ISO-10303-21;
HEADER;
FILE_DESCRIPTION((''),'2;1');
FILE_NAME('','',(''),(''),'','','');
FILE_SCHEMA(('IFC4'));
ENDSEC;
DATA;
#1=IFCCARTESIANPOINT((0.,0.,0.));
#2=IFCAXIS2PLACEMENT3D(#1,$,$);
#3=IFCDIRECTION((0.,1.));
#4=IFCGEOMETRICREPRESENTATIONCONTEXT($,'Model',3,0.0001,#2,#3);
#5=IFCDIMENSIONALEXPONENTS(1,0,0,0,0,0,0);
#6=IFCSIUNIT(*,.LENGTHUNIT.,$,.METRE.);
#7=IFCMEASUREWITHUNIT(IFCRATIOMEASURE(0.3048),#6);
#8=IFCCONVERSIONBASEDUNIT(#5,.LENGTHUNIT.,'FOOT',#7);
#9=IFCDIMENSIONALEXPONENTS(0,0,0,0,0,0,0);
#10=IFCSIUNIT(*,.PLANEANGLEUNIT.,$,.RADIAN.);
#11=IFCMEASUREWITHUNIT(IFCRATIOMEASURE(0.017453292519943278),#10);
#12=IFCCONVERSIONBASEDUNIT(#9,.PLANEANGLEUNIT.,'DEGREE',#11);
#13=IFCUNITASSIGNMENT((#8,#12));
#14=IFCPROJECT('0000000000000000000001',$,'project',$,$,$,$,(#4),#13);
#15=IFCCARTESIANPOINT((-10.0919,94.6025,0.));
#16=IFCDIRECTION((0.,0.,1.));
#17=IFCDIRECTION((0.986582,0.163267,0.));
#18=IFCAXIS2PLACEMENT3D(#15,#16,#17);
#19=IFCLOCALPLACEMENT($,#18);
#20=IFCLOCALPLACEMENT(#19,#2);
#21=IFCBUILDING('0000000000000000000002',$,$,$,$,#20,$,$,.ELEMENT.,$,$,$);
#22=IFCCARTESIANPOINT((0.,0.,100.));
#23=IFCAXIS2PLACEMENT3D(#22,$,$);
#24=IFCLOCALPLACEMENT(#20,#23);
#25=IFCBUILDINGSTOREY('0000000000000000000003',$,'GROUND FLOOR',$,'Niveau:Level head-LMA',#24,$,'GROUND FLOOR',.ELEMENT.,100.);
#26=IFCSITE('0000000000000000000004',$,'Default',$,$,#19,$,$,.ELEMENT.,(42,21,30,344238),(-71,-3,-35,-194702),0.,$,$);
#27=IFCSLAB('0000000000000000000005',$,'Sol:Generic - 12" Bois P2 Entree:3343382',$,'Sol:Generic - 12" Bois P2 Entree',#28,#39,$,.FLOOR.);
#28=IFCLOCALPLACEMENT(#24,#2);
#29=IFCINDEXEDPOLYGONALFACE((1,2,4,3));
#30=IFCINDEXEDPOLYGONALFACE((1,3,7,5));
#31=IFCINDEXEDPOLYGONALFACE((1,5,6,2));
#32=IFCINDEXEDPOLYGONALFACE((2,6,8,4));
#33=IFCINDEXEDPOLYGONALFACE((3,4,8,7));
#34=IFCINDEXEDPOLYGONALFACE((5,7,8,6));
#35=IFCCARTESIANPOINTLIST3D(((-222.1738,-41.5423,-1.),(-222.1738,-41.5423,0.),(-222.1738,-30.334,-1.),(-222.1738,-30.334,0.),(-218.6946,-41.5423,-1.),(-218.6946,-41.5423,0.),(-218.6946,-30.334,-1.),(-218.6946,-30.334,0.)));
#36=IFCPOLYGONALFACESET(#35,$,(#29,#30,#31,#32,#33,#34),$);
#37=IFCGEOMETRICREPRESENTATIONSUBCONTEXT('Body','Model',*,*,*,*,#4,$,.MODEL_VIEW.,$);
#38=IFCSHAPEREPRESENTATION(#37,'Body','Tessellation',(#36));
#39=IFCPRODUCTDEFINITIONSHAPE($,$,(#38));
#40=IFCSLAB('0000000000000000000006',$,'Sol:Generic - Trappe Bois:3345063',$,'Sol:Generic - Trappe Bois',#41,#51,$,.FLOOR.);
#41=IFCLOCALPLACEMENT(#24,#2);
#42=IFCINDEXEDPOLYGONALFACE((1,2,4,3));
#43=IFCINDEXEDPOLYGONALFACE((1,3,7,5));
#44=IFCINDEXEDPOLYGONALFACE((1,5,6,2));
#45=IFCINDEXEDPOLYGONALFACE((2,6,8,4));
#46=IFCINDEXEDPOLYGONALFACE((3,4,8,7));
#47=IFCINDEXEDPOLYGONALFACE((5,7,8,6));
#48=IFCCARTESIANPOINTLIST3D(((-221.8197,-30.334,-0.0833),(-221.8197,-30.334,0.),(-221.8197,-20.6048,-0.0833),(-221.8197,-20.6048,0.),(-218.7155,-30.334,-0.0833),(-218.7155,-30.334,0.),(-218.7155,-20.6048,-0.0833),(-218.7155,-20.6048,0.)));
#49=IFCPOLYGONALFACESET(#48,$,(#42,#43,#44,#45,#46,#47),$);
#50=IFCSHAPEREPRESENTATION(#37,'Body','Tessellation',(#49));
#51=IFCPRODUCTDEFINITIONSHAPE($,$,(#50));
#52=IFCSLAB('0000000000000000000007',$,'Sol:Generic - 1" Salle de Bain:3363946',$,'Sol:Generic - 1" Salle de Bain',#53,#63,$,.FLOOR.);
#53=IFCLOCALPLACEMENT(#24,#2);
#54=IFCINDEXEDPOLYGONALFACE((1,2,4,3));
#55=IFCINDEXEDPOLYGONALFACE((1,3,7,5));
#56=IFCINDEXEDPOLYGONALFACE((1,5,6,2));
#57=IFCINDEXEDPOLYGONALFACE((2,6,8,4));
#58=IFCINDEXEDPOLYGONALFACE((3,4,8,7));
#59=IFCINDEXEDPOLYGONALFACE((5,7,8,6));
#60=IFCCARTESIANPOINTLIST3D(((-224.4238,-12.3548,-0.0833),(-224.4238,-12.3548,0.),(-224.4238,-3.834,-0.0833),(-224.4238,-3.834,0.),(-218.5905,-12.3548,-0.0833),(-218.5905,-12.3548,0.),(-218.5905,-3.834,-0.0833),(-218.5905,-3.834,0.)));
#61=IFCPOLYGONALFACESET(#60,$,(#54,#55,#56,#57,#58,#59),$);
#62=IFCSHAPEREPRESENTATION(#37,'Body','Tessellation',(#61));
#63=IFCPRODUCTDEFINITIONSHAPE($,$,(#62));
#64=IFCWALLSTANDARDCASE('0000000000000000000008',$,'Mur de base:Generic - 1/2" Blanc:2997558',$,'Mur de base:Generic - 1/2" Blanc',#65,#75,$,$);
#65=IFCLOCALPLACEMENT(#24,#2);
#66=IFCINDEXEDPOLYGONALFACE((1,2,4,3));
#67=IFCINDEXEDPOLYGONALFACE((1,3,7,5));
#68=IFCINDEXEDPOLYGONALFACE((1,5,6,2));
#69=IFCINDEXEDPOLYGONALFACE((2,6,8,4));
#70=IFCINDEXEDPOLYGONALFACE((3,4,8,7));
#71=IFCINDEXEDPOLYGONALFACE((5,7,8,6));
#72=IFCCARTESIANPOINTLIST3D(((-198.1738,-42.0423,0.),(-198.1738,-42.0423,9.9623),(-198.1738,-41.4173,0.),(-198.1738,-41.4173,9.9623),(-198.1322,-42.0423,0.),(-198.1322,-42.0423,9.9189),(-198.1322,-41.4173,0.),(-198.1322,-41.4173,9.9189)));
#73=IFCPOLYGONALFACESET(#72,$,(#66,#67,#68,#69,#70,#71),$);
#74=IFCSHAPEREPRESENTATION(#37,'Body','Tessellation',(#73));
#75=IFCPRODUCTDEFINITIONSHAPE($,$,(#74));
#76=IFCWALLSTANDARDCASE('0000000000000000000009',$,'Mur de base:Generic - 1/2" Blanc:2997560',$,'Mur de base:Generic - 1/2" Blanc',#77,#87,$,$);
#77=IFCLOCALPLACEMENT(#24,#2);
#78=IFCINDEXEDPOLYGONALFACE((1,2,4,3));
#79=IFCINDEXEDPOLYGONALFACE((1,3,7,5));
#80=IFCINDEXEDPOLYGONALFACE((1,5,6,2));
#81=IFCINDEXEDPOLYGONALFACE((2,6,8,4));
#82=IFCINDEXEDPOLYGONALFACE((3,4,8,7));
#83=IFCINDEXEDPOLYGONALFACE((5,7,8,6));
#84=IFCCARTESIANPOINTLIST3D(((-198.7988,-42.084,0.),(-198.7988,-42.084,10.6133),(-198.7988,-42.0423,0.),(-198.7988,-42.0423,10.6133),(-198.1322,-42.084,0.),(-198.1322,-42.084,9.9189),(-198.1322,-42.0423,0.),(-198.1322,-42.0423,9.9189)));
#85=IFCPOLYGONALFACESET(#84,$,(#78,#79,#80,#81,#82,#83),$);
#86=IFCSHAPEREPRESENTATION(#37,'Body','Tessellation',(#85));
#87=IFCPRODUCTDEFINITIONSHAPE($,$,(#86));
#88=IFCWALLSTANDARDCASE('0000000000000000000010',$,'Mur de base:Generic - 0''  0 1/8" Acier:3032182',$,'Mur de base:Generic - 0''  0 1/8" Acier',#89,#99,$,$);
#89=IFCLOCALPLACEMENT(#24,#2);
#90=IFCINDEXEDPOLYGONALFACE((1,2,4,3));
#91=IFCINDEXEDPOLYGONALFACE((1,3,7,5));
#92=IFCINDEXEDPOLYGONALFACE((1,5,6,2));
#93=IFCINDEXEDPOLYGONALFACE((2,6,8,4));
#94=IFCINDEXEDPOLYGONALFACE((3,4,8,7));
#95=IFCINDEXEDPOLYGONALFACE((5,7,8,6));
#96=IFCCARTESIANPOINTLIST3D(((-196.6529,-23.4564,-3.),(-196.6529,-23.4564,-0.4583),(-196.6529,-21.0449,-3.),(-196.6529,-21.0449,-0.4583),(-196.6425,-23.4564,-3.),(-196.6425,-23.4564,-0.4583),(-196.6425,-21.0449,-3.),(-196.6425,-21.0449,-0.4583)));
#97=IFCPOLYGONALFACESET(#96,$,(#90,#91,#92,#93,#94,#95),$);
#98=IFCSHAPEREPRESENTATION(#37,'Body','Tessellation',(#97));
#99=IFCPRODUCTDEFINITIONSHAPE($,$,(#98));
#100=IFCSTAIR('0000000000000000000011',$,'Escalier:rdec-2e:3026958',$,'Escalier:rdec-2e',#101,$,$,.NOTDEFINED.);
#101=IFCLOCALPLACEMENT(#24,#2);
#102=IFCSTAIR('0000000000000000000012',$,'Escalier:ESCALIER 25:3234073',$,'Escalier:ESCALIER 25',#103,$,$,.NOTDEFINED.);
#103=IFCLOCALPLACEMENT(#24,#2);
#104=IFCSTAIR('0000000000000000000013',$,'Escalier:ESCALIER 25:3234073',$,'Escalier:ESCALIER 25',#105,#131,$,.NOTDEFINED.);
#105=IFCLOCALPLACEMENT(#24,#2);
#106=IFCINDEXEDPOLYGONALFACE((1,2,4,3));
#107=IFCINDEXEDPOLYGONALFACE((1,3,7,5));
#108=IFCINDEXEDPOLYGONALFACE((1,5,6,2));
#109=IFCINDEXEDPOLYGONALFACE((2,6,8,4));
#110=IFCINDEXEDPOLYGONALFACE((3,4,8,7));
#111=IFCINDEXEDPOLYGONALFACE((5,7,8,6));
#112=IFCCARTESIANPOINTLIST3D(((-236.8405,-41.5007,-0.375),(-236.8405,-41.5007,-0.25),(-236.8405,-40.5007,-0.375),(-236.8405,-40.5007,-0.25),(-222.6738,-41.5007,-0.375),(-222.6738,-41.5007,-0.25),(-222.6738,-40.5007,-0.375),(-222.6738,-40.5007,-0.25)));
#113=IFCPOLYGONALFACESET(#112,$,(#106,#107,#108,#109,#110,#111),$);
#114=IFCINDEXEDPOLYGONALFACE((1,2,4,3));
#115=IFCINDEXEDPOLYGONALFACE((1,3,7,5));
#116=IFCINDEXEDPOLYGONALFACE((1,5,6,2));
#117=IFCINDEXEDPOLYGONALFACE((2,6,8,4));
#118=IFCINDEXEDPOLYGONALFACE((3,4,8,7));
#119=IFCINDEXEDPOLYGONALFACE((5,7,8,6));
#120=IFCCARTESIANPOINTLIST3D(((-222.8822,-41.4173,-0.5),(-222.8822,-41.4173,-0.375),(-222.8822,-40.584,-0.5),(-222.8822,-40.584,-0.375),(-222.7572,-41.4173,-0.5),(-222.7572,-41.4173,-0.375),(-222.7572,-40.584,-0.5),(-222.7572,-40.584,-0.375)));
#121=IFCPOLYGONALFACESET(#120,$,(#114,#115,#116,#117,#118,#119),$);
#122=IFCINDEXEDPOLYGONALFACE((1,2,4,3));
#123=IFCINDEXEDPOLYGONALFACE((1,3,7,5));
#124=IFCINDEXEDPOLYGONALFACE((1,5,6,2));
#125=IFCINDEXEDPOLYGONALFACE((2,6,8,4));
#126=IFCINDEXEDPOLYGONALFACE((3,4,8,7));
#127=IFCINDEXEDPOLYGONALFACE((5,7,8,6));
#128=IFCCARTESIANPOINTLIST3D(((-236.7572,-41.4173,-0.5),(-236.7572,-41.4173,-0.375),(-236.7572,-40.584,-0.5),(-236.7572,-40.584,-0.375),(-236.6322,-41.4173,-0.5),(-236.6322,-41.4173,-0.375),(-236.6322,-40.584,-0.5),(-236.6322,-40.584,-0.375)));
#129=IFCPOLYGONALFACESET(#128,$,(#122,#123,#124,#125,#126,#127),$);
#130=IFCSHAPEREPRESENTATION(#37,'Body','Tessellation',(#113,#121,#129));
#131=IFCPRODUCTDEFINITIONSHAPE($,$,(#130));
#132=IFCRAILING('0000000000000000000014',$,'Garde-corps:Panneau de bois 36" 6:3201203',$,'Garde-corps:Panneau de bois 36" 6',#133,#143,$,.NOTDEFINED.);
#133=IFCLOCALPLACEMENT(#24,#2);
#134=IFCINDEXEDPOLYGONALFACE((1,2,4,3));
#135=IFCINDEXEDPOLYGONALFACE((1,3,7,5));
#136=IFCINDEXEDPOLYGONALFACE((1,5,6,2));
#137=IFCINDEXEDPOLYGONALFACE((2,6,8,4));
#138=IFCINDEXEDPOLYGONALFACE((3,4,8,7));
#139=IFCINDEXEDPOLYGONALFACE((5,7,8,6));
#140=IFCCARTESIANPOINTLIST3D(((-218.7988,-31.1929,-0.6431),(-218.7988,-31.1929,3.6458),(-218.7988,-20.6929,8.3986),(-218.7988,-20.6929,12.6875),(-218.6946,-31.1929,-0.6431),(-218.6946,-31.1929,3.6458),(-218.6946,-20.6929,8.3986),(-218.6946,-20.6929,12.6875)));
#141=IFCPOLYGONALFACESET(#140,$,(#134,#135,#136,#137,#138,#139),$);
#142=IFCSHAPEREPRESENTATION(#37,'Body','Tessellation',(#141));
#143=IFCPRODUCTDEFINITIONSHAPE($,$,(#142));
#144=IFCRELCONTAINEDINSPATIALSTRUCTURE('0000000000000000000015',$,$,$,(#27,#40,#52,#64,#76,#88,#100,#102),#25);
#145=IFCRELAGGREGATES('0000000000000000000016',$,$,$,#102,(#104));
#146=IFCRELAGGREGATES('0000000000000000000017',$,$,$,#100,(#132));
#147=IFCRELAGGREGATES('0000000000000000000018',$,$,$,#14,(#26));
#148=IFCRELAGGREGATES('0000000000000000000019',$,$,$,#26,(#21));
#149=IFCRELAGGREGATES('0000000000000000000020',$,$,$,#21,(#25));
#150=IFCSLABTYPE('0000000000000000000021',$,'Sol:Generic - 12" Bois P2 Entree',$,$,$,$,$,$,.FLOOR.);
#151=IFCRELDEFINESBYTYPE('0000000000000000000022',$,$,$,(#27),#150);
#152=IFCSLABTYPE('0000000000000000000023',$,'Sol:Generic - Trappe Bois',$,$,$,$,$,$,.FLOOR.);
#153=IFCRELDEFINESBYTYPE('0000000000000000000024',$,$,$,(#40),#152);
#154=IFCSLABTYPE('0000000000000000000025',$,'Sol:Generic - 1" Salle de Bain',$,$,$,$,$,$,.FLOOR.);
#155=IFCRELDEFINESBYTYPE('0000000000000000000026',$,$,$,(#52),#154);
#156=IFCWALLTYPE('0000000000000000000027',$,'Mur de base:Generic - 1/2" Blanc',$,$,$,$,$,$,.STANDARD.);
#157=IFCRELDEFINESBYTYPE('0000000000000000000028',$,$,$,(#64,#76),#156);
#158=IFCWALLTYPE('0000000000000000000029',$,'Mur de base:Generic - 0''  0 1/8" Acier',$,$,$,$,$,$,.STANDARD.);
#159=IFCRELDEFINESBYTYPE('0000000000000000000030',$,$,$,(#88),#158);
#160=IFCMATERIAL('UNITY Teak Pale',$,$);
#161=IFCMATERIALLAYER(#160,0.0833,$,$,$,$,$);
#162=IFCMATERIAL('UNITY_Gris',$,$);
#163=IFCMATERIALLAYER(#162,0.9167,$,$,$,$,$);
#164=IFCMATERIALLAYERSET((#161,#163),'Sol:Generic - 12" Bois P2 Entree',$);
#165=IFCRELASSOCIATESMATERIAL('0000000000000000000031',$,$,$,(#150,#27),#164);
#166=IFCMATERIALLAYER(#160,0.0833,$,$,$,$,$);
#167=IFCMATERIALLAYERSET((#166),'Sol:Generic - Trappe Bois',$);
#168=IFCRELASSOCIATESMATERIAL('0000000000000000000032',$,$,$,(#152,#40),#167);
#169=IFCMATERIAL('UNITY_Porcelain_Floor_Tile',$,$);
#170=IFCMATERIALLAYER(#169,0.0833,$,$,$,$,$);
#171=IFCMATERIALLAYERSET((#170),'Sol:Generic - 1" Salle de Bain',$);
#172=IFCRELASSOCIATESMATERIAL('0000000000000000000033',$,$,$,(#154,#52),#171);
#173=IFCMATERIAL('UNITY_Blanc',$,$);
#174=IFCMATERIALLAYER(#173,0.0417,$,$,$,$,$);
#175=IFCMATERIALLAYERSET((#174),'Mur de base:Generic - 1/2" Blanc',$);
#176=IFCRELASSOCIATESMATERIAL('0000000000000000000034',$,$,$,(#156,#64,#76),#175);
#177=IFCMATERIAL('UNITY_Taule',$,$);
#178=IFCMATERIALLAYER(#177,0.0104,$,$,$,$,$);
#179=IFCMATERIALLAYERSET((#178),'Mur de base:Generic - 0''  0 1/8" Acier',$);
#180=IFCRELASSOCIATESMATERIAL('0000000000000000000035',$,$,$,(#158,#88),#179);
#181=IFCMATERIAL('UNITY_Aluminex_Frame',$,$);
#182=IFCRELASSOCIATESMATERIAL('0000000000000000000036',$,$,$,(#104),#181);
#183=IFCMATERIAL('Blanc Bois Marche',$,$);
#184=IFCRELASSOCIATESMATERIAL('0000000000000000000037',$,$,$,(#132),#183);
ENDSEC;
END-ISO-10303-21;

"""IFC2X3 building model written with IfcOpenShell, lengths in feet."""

from ifc_helpers import new_model, entity, si_unit, converted_unit, direction, frame, frame_2d, origin, place, context, subcontext, project, spatial, polyline, rectangle, outline, extrude, clip, bounded_halfspace, material, layer, layer_set, layer_usage, type_object, element, aggregate, save


model = new_model("IFC2X3")

# Units and contexts
model_context = context("Model", 3, precision=0.0001, world=origin(), true_north=direction((0.0, 1.0)))
body_context = subcontext(model_context, "Body", "Model", "MODEL_VIEW")
ifc_project = project(units=[converted_unit("LENGTHUNIT", "FOOT", entity("IfcRatioMeasure", 0.3048), si_unit("LENGTHUNIT", "METRE"), dimensions=[1, 0, 0, 0, 0, 0, 0]), converted_unit("PLANEANGLEUNIT", "DEGREE", entity("IfcRatioMeasure", 0.017453292519943278), si_unit("PLANEANGLEUNIT", "RADIAN"), dimensions=[0, 0, 0, 0, 0, 0, 0])], contexts=[model_context])

# Site, building, storey
site_placement = place(None, frame((-10.0919, 94.6025, 0.0), z_axis=(0.0, 0.0, 1.0), x_axis=(0.986582, 0.163267, 0.0)))
site = spatial("IfcSite", under=ifc_project, at=site_placement, Name="Default", CompositionType="ELEMENT", RefLatitude=(42, 21, 30, 344238), RefLongitude=(-71, -3, -35, -194702), RefElevation=0.0)
building_placement = place(site_placement, origin())
building = spatial("IfcBuilding", under=site, at=building_placement, CompositionType="ELEMENT")
storey_placement = place(building_placement, frame((0.0, 0.0, 100.0)))
storey = spatial("IfcBuildingStorey", under=building, at=storey_placement, Name="GROUND FLOOR", ObjectType="Niveau:Level head-LMA", LongName="GROUND FLOOR", CompositionType="ELEMENT", Elevation=100.0)

# Slabs
ifc_material_1 = material(Name="UNITY_Gris")
ifc_material_2 = material(Name="UNITY Teak Pale")
ifc_layer_1 = layer(ifc_material_2, 0.0833)
ifc_layer_2 = layer(ifc_material_1, 0.9167)
ifc_layer_set_1 = layer_set([ifc_layer_1, ifc_layer_2], Name="Sol:Generic - 12\" Bois P2 Entree")
ifc_layer_usage_1 = layer_usage(ifc_layer_set_1, "AXIS3", "POSITIVE", 0.0)
slab_type_1 = type_object("IfcSlabType", Name="Sol:Generic - 12\" Bois P2 Entree", PredefinedType="FLOOR", material=ifc_layer_set_1)
slab_1_placement = place(storey_placement, origin())
element("IfcSlab", 1, at=slab_1_placement, inside=storey, type_object=slab_type_1, material=ifc_layer_usage_1, Name="Sol:Generic - 12\" Bois P2 Entree:3343382", ObjectType="Sol:Generic - 12\" Bois P2 Entree", PredefinedType="FLOOR", context=body_context, shape_type="SweptSolid", body=[
    extrude(rectangle(XDim=11.2083, YDim=3.4792, at=frame_2d((0.0, 0.0), x_axis=(1.0, 0.0))), frame((-220.4342, -35.9382, 0.0), z_axis=(0.0, 0.0, -1.0), x_axis=(0.0, 1.0, 0.0)), (0.0, 0.0, 1.0), 1.0),
])
ifc_layer_3 = layer(ifc_material_2, 0.0833)
ifc_layer_set_2 = layer_set([ifc_layer_3], Name="Sol:Generic - Trappe Bois")
ifc_layer_usage_2 = layer_usage(ifc_layer_set_2, "AXIS3", "POSITIVE", 0.0)
slab_type_2 = type_object("IfcSlabType", Name="Sol:Generic - Trappe Bois", PredefinedType="FLOOR", material=ifc_layer_set_2)
slab_2_placement = place(storey_placement, origin())
element("IfcSlab", 2, at=slab_2_placement, inside=storey, type_object=slab_type_2, material=ifc_layer_usage_2, Name="Sol:Generic - Trappe Bois:3345063", ObjectType="Sol:Generic - Trappe Bois", PredefinedType="FLOOR", context=body_context, shape_type="SweptSolid", body=[
    extrude(rectangle(XDim=9.7292, YDim=3.1042, at=frame_2d((0.0, 0.0), x_axis=(1.0, 0.0))), frame((-220.2676, -25.4694, 0.0), z_axis=(0.0, 0.0, -1.0), x_axis=(0.0, 1.0, 0.0)), (0.0, 0.0, 1.0), 0.0833),
])
ifc_material_3 = material(Name="UNITY_Porcelain_Floor_Tile")
ifc_layer_4 = layer(ifc_material_3, 0.0833)
ifc_layer_set_3 = layer_set([ifc_layer_4], Name="Sol:Generic - 1\" Salle de Bain")
ifc_layer_usage_3 = layer_usage(ifc_layer_set_3, "AXIS3", "POSITIVE", 0.0)
slab_type_3 = type_object("IfcSlabType", Name="Sol:Generic - 1\" Salle de Bain", PredefinedType="FLOOR", material=ifc_layer_set_3)
slab_3_placement = place(storey_placement, origin())
element("IfcSlab", 3, at=slab_3_placement, inside=storey, type_object=slab_type_3, material=ifc_layer_usage_3, Name="Sol:Generic - 1\" Salle de Bain:3363946", ObjectType="Sol:Generic - 1\" Salle de Bain", PredefinedType="FLOOR", context=body_context, shape_type="SweptSolid", body=[
    extrude(rectangle(XDim=8.5208, YDim=5.8333, at=frame_2d((0.0, 0.0), x_axis=(1.0, 0.0))), frame((-221.5072, -8.0944, 0.0), z_axis=(0.0, 0.0, -1.0), x_axis=(0.0, 1.0, 0.0)), (0.0, 0.0, 1.0), 0.0833),
])

# Walls
ifc_material_4 = material(Name="UNITY_Blanc")
ifc_layer_5 = layer(ifc_material_4, 0.0417)
ifc_layer_set_4 = layer_set([ifc_layer_5], Name="Mur de base:Generic - 1/2\" Blanc")
ifc_layer_usage_4 = layer_usage(ifc_layer_set_4, "AXIS2", "NEGATIVE", 0.0208)
wall_type_1 = type_object("IfcWallType", Name="Mur de base:Generic - 1/2\" Blanc", PredefinedType="STANDARD", material=ifc_layer_set_4)
wall_1_placement = place(storey_placement, frame((-198.153, -41.4173, 0.0), z_axis=(0.0, 0.0, 1.0), x_axis=(0.0, -1.0, 0.0)))
element("IfcWallStandardCase", 4, at=wall_1_placement, inside=storey, type_object=wall_type_1, material=ifc_layer_usage_4, Name="Mur de base:Generic - 1/2\" Blanc:2997558", ObjectType="Mur de base:Generic - 1/2\" Blanc", context=body_context, shape_type="Clipping", body=[
    clip(extrude(rectangle(XDim=0.625, YDim=0.0417, at=frame_2d((0.3125, 0.0), x_axis=(-1.0, 0.0))), origin(), (0.0, 0.0, 1.0), 9.9623), bounded_halfspace(frame((0.0, -0.0208, 9.9623), z_axis=(0.0, 0.721387, 0.692532), x_axis=(-1.0, 0.0, 0.0)), False, frame((0.0, -0.0208, 9.9623)), polyline([(0.0, 0.0), (0.625, 0.0), (0.625, 0.0417), (0.0, 0.0417), (0.0, 0.0)]))),
])
ifc_layer_usage_5 = layer_usage(ifc_layer_set_4, "AXIS2", "NEGATIVE", 0.0208)
wall_2_placement = place(storey_placement, frame((-198.1322, -42.0632, 0.0), z_axis=(0.0, 0.0, 1.0), x_axis=(-1.0, 0.0, 0.0)))
element("IfcWallStandardCase", 5, at=wall_2_placement, inside=storey, type_object=wall_type_1, material=ifc_layer_usage_5, Name="Mur de base:Generic - 1/2\" Blanc:2997560", ObjectType="Mur de base:Generic - 1/2\" Blanc", context=body_context, shape_type="Clipping", body=[
    clip(extrude(rectangle(XDim=0.6667, YDim=0.0417, at=frame_2d((0.3333, 0.0), x_axis=(-1.0, 0.0))), origin(), (0.0, 0.0, 1.0), 10.6133), bounded_halfspace(frame((0.0, -0.0208, 9.9189), z_axis=(-0.721387, 0.0, 0.692532), x_axis=(0.0, -1.0, 0.0)), False, frame((0.0, -0.0208, 9.9189)), polyline([(0.0, 0.0), (0.0417, 0.0), (0.6667, 0.0), (0.6667, 0.0417), (0.0, 0.0417), (0.0, 0.0)]))),
])
ifc_material_5 = material(Name="UNITY_Taule")
ifc_layer_6 = layer(ifc_material_5, 0.0104)
ifc_layer_set_5 = layer_set([ifc_layer_6], Name="Mur de base:Generic - 0'  0 1/8\" Acier")
ifc_layer_usage_6 = layer_usage(ifc_layer_set_5, "AXIS2", "NEGATIVE", 0.0052)
wall_type_2 = type_object("IfcWallType", Name="Mur de base:Generic - 0'  0 1/8\" Acier", PredefinedType="STANDARD", material=ifc_layer_set_5)
wall_3_placement = place(storey_placement, frame((-196.6477, -23.4564, -3.0), z_axis=(0.0, 0.0, 1.0), x_axis=(0.0, 1.0, 0.0)))
element("IfcWallStandardCase", 6, at=wall_3_placement, inside=storey, type_object=wall_type_2, material=ifc_layer_usage_6, Name="Mur de base:Generic - 0'  0 1/8\" Acier:3032182", ObjectType="Mur de base:Generic - 0'  0 1/8\" Acier", context=body_context, shape_type="SweptSolid", body=[
    extrude(rectangle(XDim=2.4115, YDim=0.0104, at=frame_2d((1.2057, 0.0), x_axis=(-1.0, 0.0))), origin(), (0.0, 0.0, 1.0), 2.5417),
])

# Stairs
stair_1_placement = place(storey_placement, origin())
stair_1 = element("IfcStair", 7, at=stair_1_placement, inside=storey, Name="Escalier:rdec-2e:3026958", ObjectType="Escalier:rdec-2e", ShapeType="NOTDEFINED")
stair_2_placement = place(storey_placement, origin())
stair_2 = element("IfcStair", 8, at=stair_2_placement, inside=storey, Name="Escalier:ESCALIER 25:3234073", ObjectType="Escalier:ESCALIER 25", ShapeType="NOTDEFINED")
ifc_material_6 = material(Name="UNITY_Aluminex_Frame")
stair_3_placement = place(stair_2_placement, origin())
stair_3 = element("IfcStair", 9, at=stair_3_placement, material=ifc_material_6, Name="Escalier:ESCALIER 25:3234073", ObjectType="Escalier:ESCALIER 25", ShapeType="NOTDEFINED", context=body_context, shape_type="SweptSolid", body=[
    extrude(rectangle(XDim=1.0, YDim=14.1667, at=frame_2d((0.0, 0.0), x_axis=(1.0, 0.0))), frame((-229.7572, -41.0007, -0.375), z_axis=(0.0, 0.0, 1.0), x_axis=(0.0, -1.0, 0.0)), (0.0, 0.0, 1.0), 0.125),
    extrude(rectangle(XDim=0.8333, YDim=0.125, at=frame_2d((0.0, 0.0), x_axis=(1.0, 0.0))), frame((-222.8197, -41.0007, -0.5), z_axis=(0.0, 0.0, 1.0), x_axis=(0.0, -1.0, 0.0)), (0.0, 0.0, 1.0), 0.125),
    extrude(rectangle(XDim=0.8333, YDim=0.125, at=frame_2d((0.0, 0.0), x_axis=(1.0, 0.0))), frame((-236.6947, -41.0007, -0.5), z_axis=(0.0, 0.0, 1.0), x_axis=(0.0, -1.0, 0.0)), (0.0, 0.0, 1.0), 0.125),
])
aggregate(stair_2, [stair_3])

# Railing
ifc_material_7 = material(Name="Blanc Bois Marche")
railing_placement = place(stair_1_placement, frame((0.0, 0.0, 9.3333)))
railing = element("IfcRailing", 10, at=railing_placement, material=ifc_material_7, Name="Garde-corps:Panneau de bois 36\" 6:3201203", ObjectType="Garde-corps:Panneau de bois 36\" 6", PredefinedType="NOTDEFINED", context=body_context, shape_type="SweptSolid", body=[
    extrude(outline(polyline([(-8.3275, -1.625), (5.5289, -1.625), (8.3275, 1.625), (-5.5289, 1.625), (-8.3275, -1.625)])), frame((-218.7988, -25.9429, -3.3111), z_axis=(1.0, 0.0, 0.0), x_axis=(0.0, -0.757769, -0.652523)), (0.0, 0.0, 1.0), 0.1042),
])
aggregate(stair_1, [railing])

save(model, "model.ifc")
